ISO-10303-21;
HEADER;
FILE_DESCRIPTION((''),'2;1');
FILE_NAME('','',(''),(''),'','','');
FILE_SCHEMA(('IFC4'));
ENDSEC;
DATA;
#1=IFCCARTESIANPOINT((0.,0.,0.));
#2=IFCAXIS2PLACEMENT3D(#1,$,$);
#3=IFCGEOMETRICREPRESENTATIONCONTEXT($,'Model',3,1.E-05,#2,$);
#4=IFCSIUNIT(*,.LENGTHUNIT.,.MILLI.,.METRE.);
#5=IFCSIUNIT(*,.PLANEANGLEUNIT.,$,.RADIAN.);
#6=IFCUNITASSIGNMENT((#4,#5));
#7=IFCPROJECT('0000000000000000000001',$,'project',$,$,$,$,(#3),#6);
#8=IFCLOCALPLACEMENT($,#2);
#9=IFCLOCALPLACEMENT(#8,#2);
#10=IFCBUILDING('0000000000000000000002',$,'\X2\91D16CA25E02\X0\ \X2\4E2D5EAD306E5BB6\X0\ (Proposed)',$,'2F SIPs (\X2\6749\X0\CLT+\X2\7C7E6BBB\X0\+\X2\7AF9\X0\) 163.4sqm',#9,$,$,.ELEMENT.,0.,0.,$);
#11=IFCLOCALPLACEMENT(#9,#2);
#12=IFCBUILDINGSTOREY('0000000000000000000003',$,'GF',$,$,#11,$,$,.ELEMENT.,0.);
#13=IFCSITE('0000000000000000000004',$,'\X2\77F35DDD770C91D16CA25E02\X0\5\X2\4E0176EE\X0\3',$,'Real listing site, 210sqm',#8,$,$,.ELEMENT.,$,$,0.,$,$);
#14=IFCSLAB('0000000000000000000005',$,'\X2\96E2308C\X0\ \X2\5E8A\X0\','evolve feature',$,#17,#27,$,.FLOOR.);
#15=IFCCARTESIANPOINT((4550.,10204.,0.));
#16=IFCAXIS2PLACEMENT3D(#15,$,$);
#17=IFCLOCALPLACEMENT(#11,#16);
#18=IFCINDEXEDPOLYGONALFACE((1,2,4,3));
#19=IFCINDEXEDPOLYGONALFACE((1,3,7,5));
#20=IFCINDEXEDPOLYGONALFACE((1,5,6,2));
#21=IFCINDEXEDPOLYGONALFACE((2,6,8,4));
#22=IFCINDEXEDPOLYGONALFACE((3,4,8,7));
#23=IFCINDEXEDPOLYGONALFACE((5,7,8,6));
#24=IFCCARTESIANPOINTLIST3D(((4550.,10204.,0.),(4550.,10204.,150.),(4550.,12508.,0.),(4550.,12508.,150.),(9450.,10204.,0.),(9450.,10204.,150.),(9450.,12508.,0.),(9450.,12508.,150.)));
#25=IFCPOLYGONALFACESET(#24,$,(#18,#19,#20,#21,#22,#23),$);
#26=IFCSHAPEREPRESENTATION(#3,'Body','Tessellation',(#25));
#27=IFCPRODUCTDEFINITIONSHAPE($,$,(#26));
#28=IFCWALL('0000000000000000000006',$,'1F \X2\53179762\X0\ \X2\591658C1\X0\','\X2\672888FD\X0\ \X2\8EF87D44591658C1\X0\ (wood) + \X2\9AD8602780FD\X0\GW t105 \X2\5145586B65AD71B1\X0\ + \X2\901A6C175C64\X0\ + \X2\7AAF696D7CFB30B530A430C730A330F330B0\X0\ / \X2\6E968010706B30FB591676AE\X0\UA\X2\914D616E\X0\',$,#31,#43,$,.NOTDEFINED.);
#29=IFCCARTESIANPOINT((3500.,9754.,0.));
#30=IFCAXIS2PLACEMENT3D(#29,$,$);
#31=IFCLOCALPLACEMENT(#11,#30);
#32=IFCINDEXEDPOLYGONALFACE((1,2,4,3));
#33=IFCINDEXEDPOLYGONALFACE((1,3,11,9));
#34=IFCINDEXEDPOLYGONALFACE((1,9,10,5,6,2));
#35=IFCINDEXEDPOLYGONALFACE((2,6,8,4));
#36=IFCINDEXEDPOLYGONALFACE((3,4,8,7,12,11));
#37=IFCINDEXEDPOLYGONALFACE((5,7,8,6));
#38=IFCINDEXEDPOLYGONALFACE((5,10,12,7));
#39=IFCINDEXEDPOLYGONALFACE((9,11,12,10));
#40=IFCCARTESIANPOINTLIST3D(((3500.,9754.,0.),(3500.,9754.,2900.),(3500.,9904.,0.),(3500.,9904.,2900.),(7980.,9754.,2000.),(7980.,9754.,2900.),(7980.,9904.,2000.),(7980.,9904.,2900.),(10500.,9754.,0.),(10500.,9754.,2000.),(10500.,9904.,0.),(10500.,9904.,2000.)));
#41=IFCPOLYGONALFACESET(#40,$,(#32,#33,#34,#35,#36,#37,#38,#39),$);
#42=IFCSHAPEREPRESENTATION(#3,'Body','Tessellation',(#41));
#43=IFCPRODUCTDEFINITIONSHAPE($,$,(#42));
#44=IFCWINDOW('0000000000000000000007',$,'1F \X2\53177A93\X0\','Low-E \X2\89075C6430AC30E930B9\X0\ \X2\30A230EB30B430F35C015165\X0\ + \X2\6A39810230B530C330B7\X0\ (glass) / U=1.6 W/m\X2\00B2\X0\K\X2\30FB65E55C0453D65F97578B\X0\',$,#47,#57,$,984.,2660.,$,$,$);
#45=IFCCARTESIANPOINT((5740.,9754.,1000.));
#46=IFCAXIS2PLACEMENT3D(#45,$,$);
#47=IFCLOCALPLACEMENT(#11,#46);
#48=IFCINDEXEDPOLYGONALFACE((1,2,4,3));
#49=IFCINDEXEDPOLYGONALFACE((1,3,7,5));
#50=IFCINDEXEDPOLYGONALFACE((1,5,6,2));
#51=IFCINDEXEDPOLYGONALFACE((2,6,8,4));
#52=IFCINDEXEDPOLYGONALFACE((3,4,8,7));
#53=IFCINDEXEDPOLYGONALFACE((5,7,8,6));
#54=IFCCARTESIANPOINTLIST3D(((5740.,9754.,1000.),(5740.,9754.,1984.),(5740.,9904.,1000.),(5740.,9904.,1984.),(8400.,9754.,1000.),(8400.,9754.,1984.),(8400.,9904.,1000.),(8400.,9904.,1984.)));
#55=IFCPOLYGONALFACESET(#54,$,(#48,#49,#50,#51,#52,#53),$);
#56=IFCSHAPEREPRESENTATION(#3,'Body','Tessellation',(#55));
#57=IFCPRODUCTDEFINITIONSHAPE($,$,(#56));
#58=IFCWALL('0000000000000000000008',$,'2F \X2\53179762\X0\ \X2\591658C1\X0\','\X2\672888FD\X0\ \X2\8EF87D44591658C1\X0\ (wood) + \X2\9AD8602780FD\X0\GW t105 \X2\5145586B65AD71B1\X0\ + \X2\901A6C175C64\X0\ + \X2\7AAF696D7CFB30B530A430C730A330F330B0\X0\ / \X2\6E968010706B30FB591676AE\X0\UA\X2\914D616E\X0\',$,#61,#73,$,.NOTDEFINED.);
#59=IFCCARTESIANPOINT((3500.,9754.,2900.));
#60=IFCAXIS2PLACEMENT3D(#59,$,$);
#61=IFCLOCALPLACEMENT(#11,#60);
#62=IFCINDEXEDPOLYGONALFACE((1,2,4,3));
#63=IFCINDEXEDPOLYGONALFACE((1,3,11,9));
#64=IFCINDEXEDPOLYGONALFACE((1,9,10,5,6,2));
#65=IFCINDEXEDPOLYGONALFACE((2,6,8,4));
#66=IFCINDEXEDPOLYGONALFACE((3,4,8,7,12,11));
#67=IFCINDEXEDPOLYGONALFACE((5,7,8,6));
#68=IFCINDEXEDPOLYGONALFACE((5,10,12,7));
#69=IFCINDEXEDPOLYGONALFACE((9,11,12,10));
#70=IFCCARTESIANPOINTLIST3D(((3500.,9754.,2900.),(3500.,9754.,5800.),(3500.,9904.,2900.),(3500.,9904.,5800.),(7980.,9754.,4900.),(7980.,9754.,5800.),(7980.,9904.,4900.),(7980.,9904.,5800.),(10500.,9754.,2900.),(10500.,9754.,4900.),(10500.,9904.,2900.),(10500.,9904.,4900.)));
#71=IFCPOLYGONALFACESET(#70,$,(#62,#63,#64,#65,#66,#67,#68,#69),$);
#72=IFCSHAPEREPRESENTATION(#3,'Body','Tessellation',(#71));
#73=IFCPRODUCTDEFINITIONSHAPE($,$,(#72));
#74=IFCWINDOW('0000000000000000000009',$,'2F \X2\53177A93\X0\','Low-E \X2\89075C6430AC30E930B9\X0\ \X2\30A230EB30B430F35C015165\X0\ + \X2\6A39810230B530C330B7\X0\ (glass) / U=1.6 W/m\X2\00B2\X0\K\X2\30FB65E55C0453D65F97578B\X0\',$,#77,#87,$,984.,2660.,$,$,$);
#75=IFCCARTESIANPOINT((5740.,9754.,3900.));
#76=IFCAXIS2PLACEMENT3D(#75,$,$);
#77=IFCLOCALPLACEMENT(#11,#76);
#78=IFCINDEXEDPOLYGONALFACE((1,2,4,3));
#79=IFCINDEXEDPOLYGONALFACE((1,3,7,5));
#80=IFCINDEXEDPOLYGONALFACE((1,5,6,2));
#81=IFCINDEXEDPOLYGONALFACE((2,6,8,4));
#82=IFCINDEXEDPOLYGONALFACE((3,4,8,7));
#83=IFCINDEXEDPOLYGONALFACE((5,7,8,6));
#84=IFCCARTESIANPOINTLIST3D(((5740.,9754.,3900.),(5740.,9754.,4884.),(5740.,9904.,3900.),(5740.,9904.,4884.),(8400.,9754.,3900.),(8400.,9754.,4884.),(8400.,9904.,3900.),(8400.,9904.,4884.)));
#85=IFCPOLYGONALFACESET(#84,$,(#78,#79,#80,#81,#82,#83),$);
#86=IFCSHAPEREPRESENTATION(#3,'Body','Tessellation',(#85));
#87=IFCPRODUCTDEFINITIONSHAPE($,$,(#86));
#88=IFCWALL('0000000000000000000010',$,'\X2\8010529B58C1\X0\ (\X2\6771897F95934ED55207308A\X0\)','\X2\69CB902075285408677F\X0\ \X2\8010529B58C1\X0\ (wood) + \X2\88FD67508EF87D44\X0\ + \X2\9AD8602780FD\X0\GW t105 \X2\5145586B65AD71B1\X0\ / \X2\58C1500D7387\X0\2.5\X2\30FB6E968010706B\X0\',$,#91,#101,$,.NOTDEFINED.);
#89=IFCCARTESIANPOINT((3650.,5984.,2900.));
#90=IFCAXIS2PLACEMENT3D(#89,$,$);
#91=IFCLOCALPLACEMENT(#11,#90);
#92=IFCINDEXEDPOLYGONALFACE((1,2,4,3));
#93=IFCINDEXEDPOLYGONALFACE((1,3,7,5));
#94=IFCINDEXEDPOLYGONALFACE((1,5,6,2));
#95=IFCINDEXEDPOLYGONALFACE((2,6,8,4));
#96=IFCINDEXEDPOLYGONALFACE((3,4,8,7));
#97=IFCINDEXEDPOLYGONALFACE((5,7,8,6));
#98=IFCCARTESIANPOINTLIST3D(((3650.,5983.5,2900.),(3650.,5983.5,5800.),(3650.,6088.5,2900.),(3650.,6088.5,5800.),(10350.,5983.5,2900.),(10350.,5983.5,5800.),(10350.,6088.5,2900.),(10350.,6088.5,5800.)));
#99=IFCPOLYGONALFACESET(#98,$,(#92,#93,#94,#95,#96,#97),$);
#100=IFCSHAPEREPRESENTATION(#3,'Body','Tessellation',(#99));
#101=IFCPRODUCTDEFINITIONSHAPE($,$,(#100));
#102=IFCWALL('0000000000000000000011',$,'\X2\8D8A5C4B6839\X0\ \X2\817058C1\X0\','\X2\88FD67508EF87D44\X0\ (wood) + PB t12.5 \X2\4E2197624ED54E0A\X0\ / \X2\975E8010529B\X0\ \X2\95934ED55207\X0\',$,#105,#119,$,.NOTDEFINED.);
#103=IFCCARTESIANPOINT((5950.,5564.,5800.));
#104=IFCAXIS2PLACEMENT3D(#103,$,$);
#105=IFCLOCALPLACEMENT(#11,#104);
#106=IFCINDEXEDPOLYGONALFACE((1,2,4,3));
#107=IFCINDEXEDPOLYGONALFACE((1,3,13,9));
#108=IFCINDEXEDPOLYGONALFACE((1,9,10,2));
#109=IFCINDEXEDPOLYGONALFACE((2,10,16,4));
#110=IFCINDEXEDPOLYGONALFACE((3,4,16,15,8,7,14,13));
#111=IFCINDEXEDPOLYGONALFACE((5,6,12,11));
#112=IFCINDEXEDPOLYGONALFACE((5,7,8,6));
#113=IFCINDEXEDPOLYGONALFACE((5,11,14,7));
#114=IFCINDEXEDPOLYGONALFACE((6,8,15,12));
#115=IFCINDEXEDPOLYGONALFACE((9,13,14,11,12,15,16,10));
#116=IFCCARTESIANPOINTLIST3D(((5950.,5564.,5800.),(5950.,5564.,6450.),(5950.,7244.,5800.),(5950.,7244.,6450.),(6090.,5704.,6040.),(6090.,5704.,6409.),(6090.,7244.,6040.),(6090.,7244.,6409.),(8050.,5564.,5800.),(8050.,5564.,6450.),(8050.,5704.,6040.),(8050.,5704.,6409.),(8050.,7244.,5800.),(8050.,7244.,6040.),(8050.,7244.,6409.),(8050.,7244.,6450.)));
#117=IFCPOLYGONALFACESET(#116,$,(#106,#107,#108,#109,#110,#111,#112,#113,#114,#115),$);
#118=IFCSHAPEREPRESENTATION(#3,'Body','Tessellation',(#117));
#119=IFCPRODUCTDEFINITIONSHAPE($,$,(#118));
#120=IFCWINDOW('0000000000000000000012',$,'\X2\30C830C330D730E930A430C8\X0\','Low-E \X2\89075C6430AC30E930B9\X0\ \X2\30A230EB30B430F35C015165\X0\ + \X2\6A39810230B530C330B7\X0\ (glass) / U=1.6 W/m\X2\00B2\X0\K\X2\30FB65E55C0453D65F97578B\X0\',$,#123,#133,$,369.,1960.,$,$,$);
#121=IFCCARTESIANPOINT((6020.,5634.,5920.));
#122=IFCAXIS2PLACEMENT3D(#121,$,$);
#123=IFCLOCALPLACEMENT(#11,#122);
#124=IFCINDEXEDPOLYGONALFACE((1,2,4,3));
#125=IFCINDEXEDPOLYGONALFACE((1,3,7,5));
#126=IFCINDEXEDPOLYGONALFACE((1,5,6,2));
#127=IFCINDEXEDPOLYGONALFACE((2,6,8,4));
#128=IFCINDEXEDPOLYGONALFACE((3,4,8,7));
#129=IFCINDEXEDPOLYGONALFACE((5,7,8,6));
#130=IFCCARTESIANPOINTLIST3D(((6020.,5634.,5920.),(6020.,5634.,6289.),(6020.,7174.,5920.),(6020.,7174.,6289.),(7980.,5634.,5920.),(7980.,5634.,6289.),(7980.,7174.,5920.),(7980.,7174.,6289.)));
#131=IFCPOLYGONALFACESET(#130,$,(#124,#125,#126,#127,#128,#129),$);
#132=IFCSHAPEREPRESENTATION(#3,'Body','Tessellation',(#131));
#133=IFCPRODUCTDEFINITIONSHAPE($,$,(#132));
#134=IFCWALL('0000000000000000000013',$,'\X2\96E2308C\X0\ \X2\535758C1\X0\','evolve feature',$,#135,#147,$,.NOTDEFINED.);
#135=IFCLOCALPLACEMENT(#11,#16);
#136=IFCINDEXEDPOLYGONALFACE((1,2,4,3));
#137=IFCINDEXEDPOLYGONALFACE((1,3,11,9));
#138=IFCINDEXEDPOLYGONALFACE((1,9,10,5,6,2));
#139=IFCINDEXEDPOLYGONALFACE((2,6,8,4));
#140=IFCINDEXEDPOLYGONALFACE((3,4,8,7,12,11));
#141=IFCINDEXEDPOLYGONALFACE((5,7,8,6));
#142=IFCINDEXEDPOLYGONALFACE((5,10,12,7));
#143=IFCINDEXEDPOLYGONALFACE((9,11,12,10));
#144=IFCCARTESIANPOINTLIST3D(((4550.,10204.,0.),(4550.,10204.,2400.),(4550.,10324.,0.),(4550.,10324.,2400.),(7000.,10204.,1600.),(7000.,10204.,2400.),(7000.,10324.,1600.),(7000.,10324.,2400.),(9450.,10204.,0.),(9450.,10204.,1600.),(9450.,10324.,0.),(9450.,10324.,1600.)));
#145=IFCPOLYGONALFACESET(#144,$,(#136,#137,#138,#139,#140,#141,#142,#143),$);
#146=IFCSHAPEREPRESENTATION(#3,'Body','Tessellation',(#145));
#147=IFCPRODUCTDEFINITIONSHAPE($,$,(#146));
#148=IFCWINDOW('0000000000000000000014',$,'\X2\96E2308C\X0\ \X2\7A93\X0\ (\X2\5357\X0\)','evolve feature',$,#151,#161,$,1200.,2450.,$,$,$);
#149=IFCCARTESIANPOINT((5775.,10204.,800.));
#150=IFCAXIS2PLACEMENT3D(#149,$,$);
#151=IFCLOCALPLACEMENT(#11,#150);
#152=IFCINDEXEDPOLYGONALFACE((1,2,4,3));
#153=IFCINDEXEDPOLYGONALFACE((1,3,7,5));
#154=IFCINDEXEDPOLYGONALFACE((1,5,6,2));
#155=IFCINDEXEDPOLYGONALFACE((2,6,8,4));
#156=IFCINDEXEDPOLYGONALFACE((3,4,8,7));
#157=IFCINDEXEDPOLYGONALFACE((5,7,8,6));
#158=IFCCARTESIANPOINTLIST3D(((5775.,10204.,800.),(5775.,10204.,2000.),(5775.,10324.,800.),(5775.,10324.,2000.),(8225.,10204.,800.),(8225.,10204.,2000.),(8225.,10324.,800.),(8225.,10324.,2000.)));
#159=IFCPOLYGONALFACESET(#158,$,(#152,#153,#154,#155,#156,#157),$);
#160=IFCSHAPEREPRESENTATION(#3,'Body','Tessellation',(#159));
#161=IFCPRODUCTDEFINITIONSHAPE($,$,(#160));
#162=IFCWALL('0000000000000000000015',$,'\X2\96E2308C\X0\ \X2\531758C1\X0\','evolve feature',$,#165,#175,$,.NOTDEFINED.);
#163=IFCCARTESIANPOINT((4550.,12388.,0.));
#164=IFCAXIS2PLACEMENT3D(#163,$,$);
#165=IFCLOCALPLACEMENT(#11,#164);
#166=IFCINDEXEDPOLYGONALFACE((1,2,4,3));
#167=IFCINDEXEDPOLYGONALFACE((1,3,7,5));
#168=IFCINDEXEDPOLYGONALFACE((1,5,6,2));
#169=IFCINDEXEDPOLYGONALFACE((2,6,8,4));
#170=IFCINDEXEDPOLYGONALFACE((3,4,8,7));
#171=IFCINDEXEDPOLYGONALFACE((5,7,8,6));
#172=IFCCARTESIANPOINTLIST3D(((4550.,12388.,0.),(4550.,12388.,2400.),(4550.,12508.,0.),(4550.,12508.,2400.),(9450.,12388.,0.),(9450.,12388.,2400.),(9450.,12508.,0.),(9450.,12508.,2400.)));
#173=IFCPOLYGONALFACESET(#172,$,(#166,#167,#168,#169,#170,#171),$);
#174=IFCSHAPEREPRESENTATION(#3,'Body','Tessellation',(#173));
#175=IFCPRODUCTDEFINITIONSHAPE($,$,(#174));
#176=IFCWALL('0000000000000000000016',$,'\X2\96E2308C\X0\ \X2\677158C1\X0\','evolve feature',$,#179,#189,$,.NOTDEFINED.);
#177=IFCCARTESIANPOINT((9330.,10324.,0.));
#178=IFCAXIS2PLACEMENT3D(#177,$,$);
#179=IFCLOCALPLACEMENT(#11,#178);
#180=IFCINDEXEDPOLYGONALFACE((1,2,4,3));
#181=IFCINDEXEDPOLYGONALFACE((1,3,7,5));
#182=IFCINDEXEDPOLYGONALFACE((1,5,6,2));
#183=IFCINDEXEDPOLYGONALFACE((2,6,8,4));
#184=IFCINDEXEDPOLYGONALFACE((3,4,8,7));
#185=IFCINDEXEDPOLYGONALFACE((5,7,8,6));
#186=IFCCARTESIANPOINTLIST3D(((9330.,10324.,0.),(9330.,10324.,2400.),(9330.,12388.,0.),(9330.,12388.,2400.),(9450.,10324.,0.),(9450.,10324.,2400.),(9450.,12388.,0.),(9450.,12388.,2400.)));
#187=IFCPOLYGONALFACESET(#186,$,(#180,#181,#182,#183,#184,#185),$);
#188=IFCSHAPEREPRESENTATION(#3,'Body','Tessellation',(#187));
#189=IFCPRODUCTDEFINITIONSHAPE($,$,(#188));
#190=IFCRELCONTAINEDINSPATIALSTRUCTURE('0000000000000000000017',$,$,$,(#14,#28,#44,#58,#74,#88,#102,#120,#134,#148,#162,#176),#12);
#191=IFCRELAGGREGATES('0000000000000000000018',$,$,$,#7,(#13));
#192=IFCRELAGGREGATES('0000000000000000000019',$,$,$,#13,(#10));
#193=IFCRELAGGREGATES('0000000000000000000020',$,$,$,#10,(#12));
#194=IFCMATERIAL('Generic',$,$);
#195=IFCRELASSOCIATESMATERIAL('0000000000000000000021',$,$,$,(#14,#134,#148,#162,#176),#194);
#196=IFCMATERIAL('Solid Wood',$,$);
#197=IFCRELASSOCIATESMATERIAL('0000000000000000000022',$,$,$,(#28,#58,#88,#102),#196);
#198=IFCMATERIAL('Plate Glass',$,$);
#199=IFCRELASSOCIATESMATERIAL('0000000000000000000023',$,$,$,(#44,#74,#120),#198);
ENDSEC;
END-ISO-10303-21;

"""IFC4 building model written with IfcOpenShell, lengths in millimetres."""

from ifc_helpers import new_model, si_unit, frame, frame_2d, origin, place, context, project, spatial, rectangle, extrude, material, element, fill, save


model = new_model("IFC4")

# Units and contexts
model_context = context("Model", 3, precision=1e-05, world=origin())
ifc_project = project(units=[si_unit("LENGTHUNIT", "METRE", prefix="MILLI"), si_unit("PLANEANGLEUNIT", "RADIAN")], contexts=[model_context])

# Site, building, storey
site_placement = place(None, origin())
site = spatial("IfcSite", under=ifc_project, at=site_placement, Name="石川県金沢市5丁目3", ObjectType="Real listing site, 210sqm", CompositionType="ELEMENT", RefElevation=0.0)
building_placement = place(site_placement, origin())
building = spatial("IfcBuilding", under=site, at=building_placement, Name="金沢市 中庭の家 (Proposed)", ObjectType="2F SIPs (杉CLT+籾殻+竹) 163.4sqm", CompositionType="ELEMENT", ElevationOfRefHeight=0.0, ElevationOfTerrain=0.0)
storey_placement = place(building_placement, origin())
storey = spatial("IfcBuildingStorey", under=building, at=storey_placement, Name="GF", CompositionType="ELEMENT", Elevation=0.0)

# Slab
ifc_material_1 = material(Name="Generic")
slab_placement = place(storey_placement, frame((4550.0, 10204.0, 0.0)))
element("IfcSlab", 1, at=slab_placement, inside=storey, material=ifc_material_1, Name="離れ 床", Description="evolve feature", PredefinedType="FLOOR", context=model_context, shape_type="SweptSolid", body=[
    extrude(rectangle(XDim=4900.0, YDim=2304.0, at=frame_2d((2450.0, 1152.0))), frame((4550.0, 10204.0, 0.0)), (0.0, 0.0, 1.0), 150.0),
])

# Wall, opening, window
ifc_material_2 = material(Name="Solid Wood")
wall_1_placement = place(storey_placement, frame((3500.0, 9754.0, 0.0)))
wall_1 = element("IfcWall", 2, at=wall_1_placement, inside=storey, material=ifc_material_2, Name="1F 北面 外壁", Description="木製 軸組外壁 (wood) + 高性能GW t105 充填断熱 + 通気層 + 窯業系サイディング / 準耐火・外皮UA配慮", PredefinedType="NOTDEFINED", context=model_context, shape_type="SweptSolid", body=[
    extrude(rectangle(XDim=7000.0, YDim=150.0, at=frame_2d((3500.0, 75.0))), frame((3500.0, 9754.0, 0.0)), (0.0, 0.0, 1.0), 2900.0),
])
opening_1_placement = place(storey_placement, frame((5740.0, 9754.0, 1000.0)))
opening_1 = element("IfcOpeningElement", 3, at=opening_1_placement, cuts=wall_1, PredefinedType="NOTDEFINED", context=model_context, shape_type="SweptSolid", body=[
    extrude(rectangle(XDim=2660.0, YDim=150.0, at=frame_2d((1330.0, 75.0))), frame((5740.0, 9754.0, 1000.0)), (0.0, 0.0, 1.0), 984.0),
])
ifc_material_3 = material(Name="Plate Glass")
window_1_placement = place(storey_placement, frame((5740.0, 9754.0, 1000.0)))
window_1 = element("IfcWindow", 4, at=window_1_placement, inside=storey, material=ifc_material_3, Name="1F 北窓", Description="Low-E 複層ガラス アルゴン封入 + 樹脂サッシ (glass) / U=1.6 W/m²K・日射取得型", OverallHeight=984.0, OverallWidth=2660.0, context=model_context, shape_type="SweptSolid", body=[
    extrude(rectangle(XDim=2660.0, YDim=150.0, at=frame_2d((1330.0, 75.0))), frame((5740.0, 9754.0, 1000.0)), (0.0, 0.0, 1.0), 984.0),
])
fill(opening_1, window_1)

# Wall, opening, window
wall_2_placement = place(storey_placement, frame((3500.0, 9754.0, 2900.0)))
wall_2 = element("IfcWall", 5, at=wall_2_placement, inside=storey, material=ifc_material_2, Name="2F 北面 外壁", Description="木製 軸組外壁 (wood) + 高性能GW t105 充填断熱 + 通気層 + 窯業系サイディング / 準耐火・外皮UA配慮", PredefinedType="NOTDEFINED", context=model_context, shape_type="SweptSolid", body=[
    extrude(rectangle(XDim=7000.0, YDim=150.0, at=frame_2d((3500.0, 75.0))), frame((3500.0, 9754.0, 2900.0)), (0.0, 0.0, 1.0), 2900.0),
])
opening_2_placement = place(storey_placement, frame((5740.0, 9754.0, 3900.0)))
opening_2 = element("IfcOpeningElement", 6, at=opening_2_placement, cuts=wall_2, PredefinedType="NOTDEFINED", context=model_context, shape_type="SweptSolid", body=[
    extrude(rectangle(XDim=2660.0, YDim=150.0, at=frame_2d((1330.0, 75.0))), frame((5740.0, 9754.0, 3900.0)), (0.0, 0.0, 1.0), 984.0),
])
window_2_placement = place(storey_placement, frame((5740.0, 9754.0, 3900.0)))
window_2 = element("IfcWindow", 7, at=window_2_placement, inside=storey, material=ifc_material_3, Name="2F 北窓", Description="Low-E 複層ガラス アルゴン封入 + 樹脂サッシ (glass) / U=1.6 W/m²K・日射取得型", OverallHeight=984.0, OverallWidth=2660.0, context=model_context, shape_type="SweptSolid", body=[
    extrude(rectangle(XDim=2660.0, YDim=150.0, at=frame_2d((1330.0, 75.0))), frame((5740.0, 9754.0, 3900.0)), (0.0, 0.0, 1.0), 984.0),
])
fill(opening_2, window_2)

# Wall
wall_3_placement = place(storey_placement, frame((3650.0, 5984.0, 2900.0)))
element("IfcWall", 8, at=wall_3_placement, inside=storey, material=ifc_material_2, Name="耐力壁 (東西間仕切り)", Description="構造用合板 耐力壁 (wood) + 製材軸組 + 高性能GW t105 充填断熱 / 壁倍率2.5・準耐火", PredefinedType="NOTDEFINED", context=model_context, shape_type="SweptSolid", body=[
    extrude(rectangle(XDim=6700.0, YDim=105.0, at=frame_2d((3350.0, 52.0))), frame((3650.0, 5984.0, 2900.0)), (0.0, 0.0, 1.0), 2900.0),
])

# Walls, openings, windows
wall_4_placement = place(storey_placement, frame((5950.0, 5564.0, 5800.0)))
wall_4 = element("IfcWall", 9, at=wall_4_placement, inside=storey, material=ifc_material_2, Name="越屋根 腰壁", Description="製材軸組 (wood) + PB t12.5 両面仕上 / 非耐力 間仕切", PredefinedType="NOTDEFINED", context=model_context, shape_type="SweptSolid", body=[
    extrude(rectangle(XDim=2100.0, YDim=1680.0, at=frame_2d((1050.0, 840.0))), frame((5950.0, 5564.0, 5800.0)), (0.0, 0.0, 1.0), 650.0),
])
opening_3_placement = place(storey_placement, frame((6020.0, 5634.0, 5920.0)))
opening_3 = element("IfcOpeningElement", 10, at=opening_3_placement, cuts=wall_4, PredefinedType="NOTDEFINED", context=model_context, shape_type="SweptSolid", body=[
    extrude(rectangle(XDim=1960.0, YDim=1540.0, at=frame_2d((980.0, 770.0))), frame((6020.0, 5634.0, 5920.0)), (0.0, 0.0, 1.0), 369.0),
])
window_3_placement = place(storey_placement, frame((6020.0, 5634.0, 5920.0)))
window_3 = element("IfcWindow", 11, at=window_3_placement, inside=storey, material=ifc_material_3, Name="トップライト", Description="Low-E 複層ガラス アルゴン封入 + 樹脂サッシ (glass) / U=1.6 W/m²K・日射取得型", OverallHeight=369.0, OverallWidth=1960.0, context=model_context, shape_type="SweptSolid", body=[
    extrude(rectangle(XDim=1960.0, YDim=1540.0, at=frame_2d((980.0, 770.0))), frame((6020.0, 5634.0, 5920.0)), (0.0, 0.0, 1.0), 369.0),
])
fill(opening_3, window_3)
wall_5_placement = place(storey_placement, frame((4550.0, 10204.0, 0.0)))
wall_5 = element("IfcWall", 12, at=wall_5_placement, inside=storey, material=ifc_material_1, Name="離れ 南壁", Description="evolve feature", PredefinedType="NOTDEFINED", context=model_context, shape_type="SweptSolid", body=[
    extrude(rectangle(XDim=4900.0, YDim=120.0, at=frame_2d((2450.0, 60.0))), frame((4550.0, 10204.0, 0.0)), (0.0, 0.0, 1.0), 2400.0),
])
opening_4_placement = place(storey_placement, frame((5775.0, 10204.0, 800.0)))
opening_4 = element("IfcOpeningElement", 13, at=opening_4_placement, cuts=wall_5, PredefinedType="NOTDEFINED", context=model_context, shape_type="SweptSolid", body=[
    extrude(rectangle(XDim=2450.0, YDim=120.0, at=frame_2d((1225.0, 60.0))), frame((5775.0, 10204.0, 800.0)), (0.0, 0.0, 1.0), 1200.0),
])
window_4_placement = place(storey_placement, frame((5775.0, 10204.0, 800.0)))
window_4 = element("IfcWindow", 14, at=window_4_placement, inside=storey, material=ifc_material_1, Name="離れ 窓 (南)", Description="evolve feature", OverallHeight=1200.0, OverallWidth=2450.0, context=model_context, shape_type="SweptSolid", body=[
    extrude(rectangle(XDim=2450.0, YDim=120.0, at=frame_2d((1225.0, 60.0))), frame((5775.0, 10204.0, 800.0)), (0.0, 0.0, 1.0), 1200.0),
])
fill(opening_4, window_4)

# Walls
wall_6_placement = place(storey_placement, frame((4550.0, 12388.0, 0.0)))
element("IfcWall", 15, at=wall_6_placement, inside=storey, material=ifc_material_1, Name="離れ 北壁", Description="evolve feature", PredefinedType="NOTDEFINED", context=model_context, shape_type="SweptSolid", body=[
    extrude(rectangle(XDim=4900.0, YDim=120.0, at=frame_2d((2450.0, 60.0))), frame((4550.0, 12388.0, 0.0)), (0.0, 0.0, 1.0), 2400.0),
])
wall_7_placement = place(storey_placement, frame((9330.0, 10324.0, 0.0)))
element("IfcWall", 16, at=wall_7_placement, inside=storey, material=ifc_material_1, Name="離れ 東壁", Description="evolve feature", PredefinedType="NOTDEFINED", context=model_context, shape_type="SweptSolid", body=[
    extrude(rectangle(XDim=120.0, YDim=2064.0, at=frame_2d((60.0, 1032.0))), frame((9330.0, 10324.0, 0.0)), (0.0, 0.0, 1.0), 2400.0),
])

save(model, "model.ifc")
